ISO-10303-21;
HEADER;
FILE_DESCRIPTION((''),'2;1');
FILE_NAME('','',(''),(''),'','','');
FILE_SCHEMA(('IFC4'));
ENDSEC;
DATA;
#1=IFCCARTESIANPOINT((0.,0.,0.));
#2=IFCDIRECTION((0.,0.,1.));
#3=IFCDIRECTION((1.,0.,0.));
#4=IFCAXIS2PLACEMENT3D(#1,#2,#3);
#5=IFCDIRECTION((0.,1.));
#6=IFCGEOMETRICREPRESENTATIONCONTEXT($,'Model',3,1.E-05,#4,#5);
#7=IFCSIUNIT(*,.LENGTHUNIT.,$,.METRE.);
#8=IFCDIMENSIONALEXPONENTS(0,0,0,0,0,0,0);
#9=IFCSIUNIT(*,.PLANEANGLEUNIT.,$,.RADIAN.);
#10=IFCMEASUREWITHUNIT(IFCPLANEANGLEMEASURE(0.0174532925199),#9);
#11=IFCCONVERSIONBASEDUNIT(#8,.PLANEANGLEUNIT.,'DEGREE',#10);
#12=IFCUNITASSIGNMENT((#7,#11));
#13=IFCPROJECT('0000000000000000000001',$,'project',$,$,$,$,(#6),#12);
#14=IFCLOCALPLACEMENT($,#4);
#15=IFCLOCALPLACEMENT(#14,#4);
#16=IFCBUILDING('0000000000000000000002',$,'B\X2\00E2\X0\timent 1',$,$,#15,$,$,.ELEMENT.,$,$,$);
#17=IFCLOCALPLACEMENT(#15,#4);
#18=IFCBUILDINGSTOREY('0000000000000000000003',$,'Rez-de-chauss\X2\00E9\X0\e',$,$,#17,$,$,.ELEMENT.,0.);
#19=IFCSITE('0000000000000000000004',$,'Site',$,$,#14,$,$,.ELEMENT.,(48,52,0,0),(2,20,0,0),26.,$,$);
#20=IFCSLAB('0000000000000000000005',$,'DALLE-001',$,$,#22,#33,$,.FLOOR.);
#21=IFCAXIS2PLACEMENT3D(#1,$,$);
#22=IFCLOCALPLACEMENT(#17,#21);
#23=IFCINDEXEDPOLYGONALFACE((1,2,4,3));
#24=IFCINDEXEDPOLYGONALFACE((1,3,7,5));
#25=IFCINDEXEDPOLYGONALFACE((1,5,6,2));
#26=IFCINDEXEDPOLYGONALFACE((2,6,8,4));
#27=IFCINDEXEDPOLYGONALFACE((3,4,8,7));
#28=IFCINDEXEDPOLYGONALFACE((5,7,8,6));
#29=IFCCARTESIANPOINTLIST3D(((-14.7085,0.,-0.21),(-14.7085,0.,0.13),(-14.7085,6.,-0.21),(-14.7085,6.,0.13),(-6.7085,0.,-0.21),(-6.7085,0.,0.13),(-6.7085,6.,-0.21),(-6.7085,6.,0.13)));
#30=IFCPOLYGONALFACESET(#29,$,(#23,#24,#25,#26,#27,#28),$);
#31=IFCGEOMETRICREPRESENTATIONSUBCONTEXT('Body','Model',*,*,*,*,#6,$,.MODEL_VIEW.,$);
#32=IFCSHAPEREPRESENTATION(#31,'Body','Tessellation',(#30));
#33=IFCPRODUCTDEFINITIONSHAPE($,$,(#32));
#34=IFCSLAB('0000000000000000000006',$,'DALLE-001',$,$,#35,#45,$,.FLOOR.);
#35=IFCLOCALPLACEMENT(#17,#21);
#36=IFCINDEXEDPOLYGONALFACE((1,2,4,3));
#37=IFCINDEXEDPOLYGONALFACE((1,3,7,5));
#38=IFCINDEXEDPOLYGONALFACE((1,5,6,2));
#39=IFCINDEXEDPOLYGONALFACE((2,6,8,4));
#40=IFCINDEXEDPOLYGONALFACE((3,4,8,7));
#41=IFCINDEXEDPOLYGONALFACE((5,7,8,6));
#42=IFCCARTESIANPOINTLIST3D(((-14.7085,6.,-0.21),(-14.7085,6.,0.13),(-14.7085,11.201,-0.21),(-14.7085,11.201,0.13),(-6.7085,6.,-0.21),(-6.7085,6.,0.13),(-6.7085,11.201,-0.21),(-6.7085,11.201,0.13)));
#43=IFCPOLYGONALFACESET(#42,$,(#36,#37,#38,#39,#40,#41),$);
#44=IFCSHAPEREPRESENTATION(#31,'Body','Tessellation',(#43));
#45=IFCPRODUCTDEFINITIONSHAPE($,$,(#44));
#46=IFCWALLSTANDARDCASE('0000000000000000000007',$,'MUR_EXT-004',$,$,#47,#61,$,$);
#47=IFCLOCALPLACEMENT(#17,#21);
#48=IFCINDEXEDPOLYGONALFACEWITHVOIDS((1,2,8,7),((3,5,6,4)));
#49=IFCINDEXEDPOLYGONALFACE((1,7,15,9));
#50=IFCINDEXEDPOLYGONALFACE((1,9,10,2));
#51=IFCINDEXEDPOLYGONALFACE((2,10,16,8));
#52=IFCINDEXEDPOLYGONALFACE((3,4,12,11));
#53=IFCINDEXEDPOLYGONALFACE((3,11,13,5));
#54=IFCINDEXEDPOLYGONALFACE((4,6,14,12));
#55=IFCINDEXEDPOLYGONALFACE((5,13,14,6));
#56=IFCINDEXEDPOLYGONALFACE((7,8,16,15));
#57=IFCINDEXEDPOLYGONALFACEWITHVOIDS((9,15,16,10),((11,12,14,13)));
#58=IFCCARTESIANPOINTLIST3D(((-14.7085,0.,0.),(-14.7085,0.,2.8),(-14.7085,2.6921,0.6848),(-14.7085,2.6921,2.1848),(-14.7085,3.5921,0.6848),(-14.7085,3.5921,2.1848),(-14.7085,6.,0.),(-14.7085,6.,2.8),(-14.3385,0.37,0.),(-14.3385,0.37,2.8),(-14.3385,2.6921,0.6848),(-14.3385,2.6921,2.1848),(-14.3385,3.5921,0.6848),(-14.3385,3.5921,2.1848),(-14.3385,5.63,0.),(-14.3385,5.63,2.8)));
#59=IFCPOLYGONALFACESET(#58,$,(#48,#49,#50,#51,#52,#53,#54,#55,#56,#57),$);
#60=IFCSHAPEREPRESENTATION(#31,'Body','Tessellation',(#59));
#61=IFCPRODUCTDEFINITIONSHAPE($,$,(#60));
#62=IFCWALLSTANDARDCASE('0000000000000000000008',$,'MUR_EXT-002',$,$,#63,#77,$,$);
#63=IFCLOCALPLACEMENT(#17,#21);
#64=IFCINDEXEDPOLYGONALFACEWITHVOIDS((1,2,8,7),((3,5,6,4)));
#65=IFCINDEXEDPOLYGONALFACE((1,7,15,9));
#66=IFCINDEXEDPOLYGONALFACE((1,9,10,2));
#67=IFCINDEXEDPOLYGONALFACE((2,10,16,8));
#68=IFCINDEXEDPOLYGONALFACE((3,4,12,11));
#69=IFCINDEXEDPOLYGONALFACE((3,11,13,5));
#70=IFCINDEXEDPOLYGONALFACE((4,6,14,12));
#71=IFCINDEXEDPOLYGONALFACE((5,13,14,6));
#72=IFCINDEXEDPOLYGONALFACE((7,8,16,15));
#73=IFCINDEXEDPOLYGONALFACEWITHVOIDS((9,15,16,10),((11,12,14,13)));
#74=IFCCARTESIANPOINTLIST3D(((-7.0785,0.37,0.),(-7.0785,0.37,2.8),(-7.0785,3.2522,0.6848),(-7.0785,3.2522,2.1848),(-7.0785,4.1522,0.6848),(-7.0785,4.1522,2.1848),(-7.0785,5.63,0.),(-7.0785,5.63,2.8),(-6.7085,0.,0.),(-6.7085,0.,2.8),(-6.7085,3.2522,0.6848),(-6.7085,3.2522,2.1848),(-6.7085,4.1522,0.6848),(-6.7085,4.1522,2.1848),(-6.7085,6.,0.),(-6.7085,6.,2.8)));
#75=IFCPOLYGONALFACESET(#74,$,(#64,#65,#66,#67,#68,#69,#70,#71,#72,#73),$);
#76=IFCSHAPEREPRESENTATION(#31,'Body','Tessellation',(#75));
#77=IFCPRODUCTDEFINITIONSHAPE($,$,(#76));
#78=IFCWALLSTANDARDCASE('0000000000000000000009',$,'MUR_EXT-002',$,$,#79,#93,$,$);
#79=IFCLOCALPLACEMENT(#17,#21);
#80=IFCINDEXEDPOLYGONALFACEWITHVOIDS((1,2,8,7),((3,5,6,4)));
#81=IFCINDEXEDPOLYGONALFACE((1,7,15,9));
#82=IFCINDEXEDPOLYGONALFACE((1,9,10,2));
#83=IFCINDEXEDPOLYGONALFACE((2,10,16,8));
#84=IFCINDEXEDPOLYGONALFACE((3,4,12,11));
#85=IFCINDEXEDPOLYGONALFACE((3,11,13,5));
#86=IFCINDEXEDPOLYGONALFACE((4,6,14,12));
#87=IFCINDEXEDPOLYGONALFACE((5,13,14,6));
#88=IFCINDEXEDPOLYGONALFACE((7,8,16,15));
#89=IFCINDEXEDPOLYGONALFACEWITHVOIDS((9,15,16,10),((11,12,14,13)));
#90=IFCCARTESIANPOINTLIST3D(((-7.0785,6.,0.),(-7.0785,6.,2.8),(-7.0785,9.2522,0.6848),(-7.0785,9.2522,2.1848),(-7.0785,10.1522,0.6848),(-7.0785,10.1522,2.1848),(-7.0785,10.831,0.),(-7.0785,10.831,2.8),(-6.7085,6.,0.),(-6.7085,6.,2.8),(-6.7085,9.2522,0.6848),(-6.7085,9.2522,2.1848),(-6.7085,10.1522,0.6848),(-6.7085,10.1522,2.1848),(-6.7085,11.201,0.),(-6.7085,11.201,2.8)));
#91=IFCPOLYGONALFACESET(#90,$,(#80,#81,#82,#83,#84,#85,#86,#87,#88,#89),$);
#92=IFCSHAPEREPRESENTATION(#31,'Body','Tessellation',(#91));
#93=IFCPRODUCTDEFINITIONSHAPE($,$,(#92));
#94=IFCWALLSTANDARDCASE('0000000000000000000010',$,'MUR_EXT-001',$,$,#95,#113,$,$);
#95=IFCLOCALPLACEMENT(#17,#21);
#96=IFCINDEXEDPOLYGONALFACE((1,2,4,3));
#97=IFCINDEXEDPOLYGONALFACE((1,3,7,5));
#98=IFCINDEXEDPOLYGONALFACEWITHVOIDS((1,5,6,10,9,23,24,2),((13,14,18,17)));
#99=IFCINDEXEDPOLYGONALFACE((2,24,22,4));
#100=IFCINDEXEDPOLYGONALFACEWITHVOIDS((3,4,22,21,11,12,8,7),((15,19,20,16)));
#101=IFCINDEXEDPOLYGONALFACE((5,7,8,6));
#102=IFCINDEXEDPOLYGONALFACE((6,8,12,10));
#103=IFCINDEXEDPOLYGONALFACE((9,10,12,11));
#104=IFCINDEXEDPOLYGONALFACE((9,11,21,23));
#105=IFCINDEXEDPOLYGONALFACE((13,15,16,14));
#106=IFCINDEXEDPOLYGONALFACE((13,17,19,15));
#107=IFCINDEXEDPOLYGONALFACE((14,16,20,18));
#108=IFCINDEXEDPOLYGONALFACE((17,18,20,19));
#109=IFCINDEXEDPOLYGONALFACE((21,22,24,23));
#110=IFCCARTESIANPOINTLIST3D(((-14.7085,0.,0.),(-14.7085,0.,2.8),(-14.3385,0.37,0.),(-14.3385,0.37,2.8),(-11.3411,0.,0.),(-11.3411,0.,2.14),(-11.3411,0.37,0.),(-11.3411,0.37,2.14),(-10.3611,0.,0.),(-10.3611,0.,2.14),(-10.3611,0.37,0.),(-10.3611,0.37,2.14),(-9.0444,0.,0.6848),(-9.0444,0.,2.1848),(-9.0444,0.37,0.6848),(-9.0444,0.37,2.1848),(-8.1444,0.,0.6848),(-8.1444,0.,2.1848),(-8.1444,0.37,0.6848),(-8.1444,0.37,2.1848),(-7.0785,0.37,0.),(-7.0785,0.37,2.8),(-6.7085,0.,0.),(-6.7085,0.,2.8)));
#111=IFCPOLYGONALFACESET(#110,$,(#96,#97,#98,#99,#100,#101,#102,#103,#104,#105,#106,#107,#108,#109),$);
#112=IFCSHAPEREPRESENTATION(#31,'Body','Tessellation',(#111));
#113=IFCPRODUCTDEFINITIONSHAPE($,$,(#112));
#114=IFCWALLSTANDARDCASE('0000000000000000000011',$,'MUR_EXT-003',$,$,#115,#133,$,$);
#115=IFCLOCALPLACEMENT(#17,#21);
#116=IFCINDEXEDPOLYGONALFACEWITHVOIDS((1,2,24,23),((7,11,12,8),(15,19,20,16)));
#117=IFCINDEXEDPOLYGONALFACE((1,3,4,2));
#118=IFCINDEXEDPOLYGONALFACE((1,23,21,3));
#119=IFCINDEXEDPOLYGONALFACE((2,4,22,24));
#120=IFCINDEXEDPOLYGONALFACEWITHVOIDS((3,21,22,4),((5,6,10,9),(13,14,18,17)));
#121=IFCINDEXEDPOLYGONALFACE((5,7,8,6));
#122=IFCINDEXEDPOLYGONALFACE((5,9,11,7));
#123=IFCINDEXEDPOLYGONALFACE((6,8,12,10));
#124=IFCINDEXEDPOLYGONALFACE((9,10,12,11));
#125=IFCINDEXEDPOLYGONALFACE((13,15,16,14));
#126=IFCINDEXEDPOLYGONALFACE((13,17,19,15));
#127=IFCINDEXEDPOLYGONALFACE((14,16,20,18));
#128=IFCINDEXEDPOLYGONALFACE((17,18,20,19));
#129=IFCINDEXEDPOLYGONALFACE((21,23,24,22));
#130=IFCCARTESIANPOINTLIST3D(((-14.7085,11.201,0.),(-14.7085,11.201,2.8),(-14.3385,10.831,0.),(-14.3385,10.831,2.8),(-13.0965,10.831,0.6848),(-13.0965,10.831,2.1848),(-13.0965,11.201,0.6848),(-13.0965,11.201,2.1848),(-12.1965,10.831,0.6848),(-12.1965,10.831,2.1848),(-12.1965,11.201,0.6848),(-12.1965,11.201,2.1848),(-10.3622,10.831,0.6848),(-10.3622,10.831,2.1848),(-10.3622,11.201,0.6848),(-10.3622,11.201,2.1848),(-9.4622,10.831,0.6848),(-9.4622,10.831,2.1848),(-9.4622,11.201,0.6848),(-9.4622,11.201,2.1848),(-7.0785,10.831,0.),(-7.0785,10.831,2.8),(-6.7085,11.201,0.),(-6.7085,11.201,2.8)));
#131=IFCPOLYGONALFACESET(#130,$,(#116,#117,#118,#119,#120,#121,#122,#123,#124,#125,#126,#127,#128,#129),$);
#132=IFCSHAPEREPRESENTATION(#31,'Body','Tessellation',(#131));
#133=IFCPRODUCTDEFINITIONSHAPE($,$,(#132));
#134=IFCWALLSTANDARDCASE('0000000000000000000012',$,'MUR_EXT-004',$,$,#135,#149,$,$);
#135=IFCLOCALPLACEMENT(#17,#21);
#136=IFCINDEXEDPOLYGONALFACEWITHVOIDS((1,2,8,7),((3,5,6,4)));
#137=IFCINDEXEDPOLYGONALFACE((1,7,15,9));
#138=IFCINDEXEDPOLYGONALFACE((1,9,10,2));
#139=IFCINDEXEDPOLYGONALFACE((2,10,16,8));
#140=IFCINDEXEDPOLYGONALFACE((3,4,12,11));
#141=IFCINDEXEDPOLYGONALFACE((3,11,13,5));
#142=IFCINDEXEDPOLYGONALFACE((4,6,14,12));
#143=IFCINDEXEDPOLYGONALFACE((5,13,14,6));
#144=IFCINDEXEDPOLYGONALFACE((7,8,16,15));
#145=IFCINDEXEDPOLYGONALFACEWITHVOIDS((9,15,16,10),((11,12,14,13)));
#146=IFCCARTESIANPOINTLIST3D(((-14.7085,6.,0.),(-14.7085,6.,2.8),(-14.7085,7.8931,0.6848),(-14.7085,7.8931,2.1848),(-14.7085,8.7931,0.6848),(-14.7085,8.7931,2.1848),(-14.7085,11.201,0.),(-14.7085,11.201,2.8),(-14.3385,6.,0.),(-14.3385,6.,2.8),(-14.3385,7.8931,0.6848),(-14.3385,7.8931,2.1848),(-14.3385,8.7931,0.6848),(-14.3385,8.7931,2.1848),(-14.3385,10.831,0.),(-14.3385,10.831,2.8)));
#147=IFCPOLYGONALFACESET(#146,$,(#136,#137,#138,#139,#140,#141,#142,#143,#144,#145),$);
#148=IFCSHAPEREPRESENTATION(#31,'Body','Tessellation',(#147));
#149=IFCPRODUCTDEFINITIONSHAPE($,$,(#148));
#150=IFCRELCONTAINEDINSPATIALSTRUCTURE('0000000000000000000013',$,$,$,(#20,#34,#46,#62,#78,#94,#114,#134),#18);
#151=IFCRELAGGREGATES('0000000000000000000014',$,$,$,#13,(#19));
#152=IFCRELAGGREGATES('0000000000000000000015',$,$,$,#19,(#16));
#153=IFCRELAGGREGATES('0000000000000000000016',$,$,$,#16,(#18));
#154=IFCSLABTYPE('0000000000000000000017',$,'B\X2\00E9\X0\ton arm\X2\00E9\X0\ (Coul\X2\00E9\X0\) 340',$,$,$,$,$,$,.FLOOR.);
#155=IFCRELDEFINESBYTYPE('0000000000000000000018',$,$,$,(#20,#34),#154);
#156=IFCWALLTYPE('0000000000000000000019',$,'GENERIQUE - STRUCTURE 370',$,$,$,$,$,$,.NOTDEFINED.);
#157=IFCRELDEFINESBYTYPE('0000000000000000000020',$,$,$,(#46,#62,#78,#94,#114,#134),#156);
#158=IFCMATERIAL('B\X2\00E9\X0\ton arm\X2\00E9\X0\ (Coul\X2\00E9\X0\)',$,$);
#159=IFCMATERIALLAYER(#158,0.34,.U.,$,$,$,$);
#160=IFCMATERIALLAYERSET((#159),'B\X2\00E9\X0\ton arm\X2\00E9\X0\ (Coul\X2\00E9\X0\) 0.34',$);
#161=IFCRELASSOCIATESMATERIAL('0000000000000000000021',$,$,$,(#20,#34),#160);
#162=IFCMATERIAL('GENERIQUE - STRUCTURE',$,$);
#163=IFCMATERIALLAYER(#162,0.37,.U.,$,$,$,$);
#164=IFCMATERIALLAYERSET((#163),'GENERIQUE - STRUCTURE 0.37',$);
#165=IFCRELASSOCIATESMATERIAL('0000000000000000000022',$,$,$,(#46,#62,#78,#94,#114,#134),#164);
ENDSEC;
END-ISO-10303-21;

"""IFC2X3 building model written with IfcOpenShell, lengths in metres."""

from ifc_helpers import new_model, entity, si_unit, converted_unit, direction, frame, origin_with_axes, origin_2d_with_axis, place, context, subcontext, project, spatial, polyline, rectangle, outline, extrude, material, layer, layer_set, layer_usage, type_object, element, save


model = new_model("IFC2X3")

# Units and contexts
model_context = context("Model", 3, precision=1e-05, world=origin_with_axes(), true_north=direction((0.0, 1.0)))
body_context = subcontext(model_context, "Body", "Model", "MODEL_VIEW")
ifc_project = project(units=[si_unit("LENGTHUNIT", "METRE"), converted_unit("PLANEANGLEUNIT", "DEGREE", entity("IfcPlaneAngleMeasure", 0.0174532925199), si_unit("PLANEANGLEUNIT", "RADIAN"), dimensions=[0, 0, 0, 0, 0, 0, 0])], contexts=[model_context])

# Site, building, storey
site_placement = place(None, origin_with_axes())
site = spatial("IfcSite", under=ifc_project, at=site_placement, Name="Site", CompositionType="ELEMENT", RefLatitude=(48, 52, 0, 0), RefLongitude=(2, 20, 0, 0), RefElevation=26.0)
building_placement = place(site_placement, origin_with_axes())
building = spatial("IfcBuilding", under=site, at=building_placement, Name="Bâtiment 1", CompositionType="ELEMENT")
storey_placement = place(building_placement, origin_with_axes())
storey = spatial("IfcBuildingStorey", under=building, at=storey_placement, Name="Rez-de-chaussée", CompositionType="ELEMENT", Elevation=0.0)

# Slabs
ifc_material_1 = material(Name="Béton armé (Coulé)")
ifc_layer_1 = layer(ifc_material_1, 0.34, ventilated="UNKNOWN")
ifc_layer_set_1 = layer_set([ifc_layer_1], Name="Béton armé (Coulé) 0.34")
ifc_layer_usage_1 = layer_usage(ifc_layer_set_1, "AXIS3", "NEGATIVE", 0.34)
slab_type = type_object("IfcSlabType", Name="Béton armé (Coulé) 340", PredefinedType="FLOOR")
slab_1_placement = place(storey_placement, frame((-14.7085, 0.0, 0.13), z_axis=(0.0, 0.0, 1.0), x_axis=(1.0, 0.0, 0.0)))
element("IfcSlab", 1, at=slab_1_placement, inside=storey, type_object=slab_type, material=ifc_layer_usage_1, Name="DALLE-001", PredefinedType="FLOOR", context=body_context, shape_type="SweptSolid", body=[
    extrude(outline(polyline([(0.0, 0.0), (8.0, 0.0), (8.0, 6.0), (0.0, 6.0), (0.0, 0.0)])), frame((0.0, 0.0, -0.34), z_axis=(0.0, 0.0, 1.0), x_axis=(1.0, 0.0, 0.0)), (0.0, 0.0, 1.0), 0.34),
])
ifc_layer_usage_2 = layer_usage(ifc_layer_set_1, "AXIS3", "NEGATIVE", 0.34)
slab_2_placement = place(storey_placement, frame((-14.7085, 6.0, 0.13), z_axis=(0.0, 0.0, 1.0), x_axis=(1.0, 0.0, 0.0)))
element("IfcSlab", 2, at=slab_2_placement, inside=storey, type_object=slab_type, material=ifc_layer_usage_2, Name="DALLE-001", PredefinedType="FLOOR", context=body_context, shape_type="SweptSolid", body=[
    extrude(outline(polyline([(0.0, 0.0), (8.0, 0.0), (8.0, 5.201), (0.0, 5.201), (0.0, 0.0)])), frame((0.0, 0.0, -0.34), z_axis=(0.0, 0.0, 1.0), x_axis=(1.0, 0.0, 0.0)), (0.0, 0.0, 1.0), 0.34),
])

# Walls, openings
ifc_material_2 = material(Name="GENERIQUE - STRUCTURE")
ifc_layer_2 = layer(ifc_material_2, 0.37, ventilated="UNKNOWN")
ifc_layer_set_2 = layer_set([ifc_layer_2], Name="GENERIQUE - STRUCTURE 0.37")
ifc_layer_usage_3 = layer_usage(ifc_layer_set_2, "AXIS2", "POSITIVE", 0.0)
wall_type_1 = type_object("IfcWallType", Name="GENERIQUE - STRUCTURE 370", PredefinedType="NOTDEFINED")
wall_1_placement = place(storey_placement, frame((-14.7085, 6.0, 0.0), z_axis=(0.0, 0.0, 1.0), x_axis=(0.0, -1.0, 0.0)))
wall_1 = element("IfcWallStandardCase", 3, at=wall_1_placement, inside=storey, type_object=wall_type_1, material=ifc_layer_usage_3, Name="MUR_EXT-004", context=body_context, shape_type="SweptSolid", body=[
    extrude(outline(polyline([(0.0, 0.0), (6.0, 0.0), (5.63, 0.37), (0.37, 0.37), (0.0, 0.0)])), origin_with_axes(), (0.0, 0.0, 1.0), 2.8),
])
opening_1_placement = place(wall_1_placement, frame((2.8579, 0.0, 0.6848), z_axis=(0.0, 0.0, 1.0), x_axis=(1.0, 0.0, 0.0)))
element("IfcOpeningElement", 4, at=opening_1_placement, cuts=wall_1, context=body_context, shape_type="SweptSolid", body=[
    extrude(rectangle(XDim=0.9, YDim=1.5, at=origin_2d_with_axis()), frame((0.0, 0.37, 0.75), z_axis=(0.0, -1.0, 0.0), x_axis=(-1.0, 0.0, 0.0)), (0.0, 0.0, 1.0), 1.11),
])
ifc_layer_usage_4 = layer_usage(ifc_layer_set_2, "AXIS2", "POSITIVE", 0.0)
wall_2_placement = place(storey_placement, frame((-6.7085, 0.0, 0.0), z_axis=(0.0, 0.0, 1.0), x_axis=(0.0, 1.0, 0.0)))
wall_2 = element("IfcWallStandardCase", 5, at=wall_2_placement, inside=storey, type_object=wall_type_1, material=ifc_layer_usage_4, Name="MUR_EXT-002", context=body_context, shape_type="SweptSolid", body=[
    extrude(outline(polyline([(0.0, 0.0), (6.0, 0.0), (5.63, 0.37), (0.37, 0.37), (0.0, 0.0)])), origin_with_axes(), (0.0, 0.0, 1.0), 2.8),
])
opening_2_placement = place(wall_2_placement, frame((3.7022, 0.0, 0.6848), z_axis=(0.0, 0.0, 1.0), x_axis=(1.0, 0.0, 0.0)))
element("IfcOpeningElement", 6, at=opening_2_placement, cuts=wall_2, context=body_context, shape_type="SweptSolid", body=[
    extrude(rectangle(XDim=0.9, YDim=1.5, at=origin_2d_with_axis()), frame((0.0, 0.37, 0.75), z_axis=(0.0, -1.0, 0.0), x_axis=(-1.0, 0.0, 0.0)), (0.0, 0.0, 1.0), 1.11),
])
ifc_layer_usage_5 = layer_usage(ifc_layer_set_2, "AXIS2", "POSITIVE", 0.0)
wall_3_placement = place(storey_placement, frame((-6.7085, 6.0, 0.0), z_axis=(0.0, 0.0, 1.0), x_axis=(0.0, 1.0, 0.0)))
wall_3 = element("IfcWallStandardCase", 7, at=wall_3_placement, inside=storey, type_object=wall_type_1, material=ifc_layer_usage_5, Name="MUR_EXT-002", context=body_context, shape_type="SweptSolid", body=[
    extrude(outline(polyline([(0.0, 0.0), (5.201, 0.0), (4.831, 0.37), (0.0, 0.37), (0.0, 0.0)])), origin_with_axes(), (0.0, 0.0, 1.0), 2.8),
])
opening_3_placement = place(wall_3_placement, frame((3.7022, 0.0, 0.6848), z_axis=(0.0, 0.0, 1.0), x_axis=(1.0, 0.0, 0.0)))
element("IfcOpeningElement", 8, at=opening_3_placement, cuts=wall_3, context=body_context, shape_type="SweptSolid", body=[
    extrude(rectangle(XDim=0.9, YDim=1.5, at=origin_2d_with_axis()), frame((0.0, 0.37, 0.75), z_axis=(0.0, -1.0, 0.0), x_axis=(-1.0, 0.0, 0.0)), (0.0, 0.0, 1.0), 1.11),
])

# Walls, openings
ifc_layer_usage_6 = layer_usage(ifc_layer_set_2, "AXIS2", "POSITIVE", 0.0)
wall_4_placement = place(storey_placement, frame((-14.7085, 0.0, 0.0), z_axis=(0.0, 0.0, 1.0), x_axis=(1.0, 0.0, 0.0)))
wall_4 = element("IfcWallStandardCase", 9, at=wall_4_placement, inside=storey, type_object=wall_type_1, material=ifc_layer_usage_6, Name="MUR_EXT-001", context=body_context, shape_type="SweptSolid", body=[
    extrude(outline(polyline([(0.0, 0.0), (8.0, 0.0), (7.63, 0.37), (0.37, 0.37), (0.0, 0.0)])), origin_with_axes(), (0.0, 0.0, 1.0), 2.8),
])
opening_4_placement = place(wall_4_placement, frame((6.1141, 0.0, 0.6848), z_axis=(0.0, 0.0, 1.0), x_axis=(1.0, 0.0, 0.0)))
element("IfcOpeningElement", 10, at=opening_4_placement, cuts=wall_4, context=body_context, shape_type="SweptSolid", body=[
    extrude(rectangle(XDim=0.9, YDim=1.5, at=origin_2d_with_axis()), frame((0.0, 0.37, 0.75), z_axis=(0.0, 1.0, 0.0), x_axis=(1.0, 0.0, 0.0)), (0.0, 0.0, -1.0), 1.11),
])
opening_5_placement = place(wall_4_placement, frame((3.8574, 0.0, 0.0), z_axis=(0.0, 0.0, 1.0), x_axis=(1.0, 0.0, 0.0)))
element("IfcOpeningElement", 11, at=opening_5_placement, cuts=wall_4, context=body_context, shape_type="SweptSolid", body=[
    extrude(rectangle(XDim=0.98, YDim=2.14, at=origin_2d_with_axis()), frame((0.0, 0.37, 1.07), z_axis=(0.0, 1.0, 0.0), x_axis=(1.0, 0.0, 0.0)), (0.0, 0.0, -1.0), 1.11),
])
ifc_layer_usage_7 = layer_usage(ifc_layer_set_2, "AXIS2", "POSITIVE", 0.0)
wall_5_placement = place(storey_placement, frame((-6.7085, 11.201, 0.0), z_axis=(0.0, 0.0, 1.0), x_axis=(-1.0, 0.0, 0.0)))
wall_5 = element("IfcWallStandardCase", 12, at=wall_5_placement, inside=storey, type_object=wall_type_1, material=ifc_layer_usage_7, Name="MUR_EXT-003", context=body_context, shape_type="SweptSolid", body=[
    extrude(outline(polyline([(0.0, 0.0), (8.0, 0.0), (7.63, 0.37), (0.37, 0.37), (0.0, 0.0)])), origin_with_axes(), (0.0, 0.0, 1.0), 2.8),
])
opening_6_placement = place(wall_5_placement, frame((3.2036, 0.0, 0.6848), z_axis=(0.0, 0.0, 1.0), x_axis=(1.0, 0.0, 0.0)))
element("IfcOpeningElement", 13, at=opening_6_placement, cuts=wall_5, context=body_context, shape_type="SweptSolid", body=[
    extrude(rectangle(XDim=0.9, YDim=1.5, at=origin_2d_with_axis()), frame((0.0, 0.37, 0.75), z_axis=(0.0, -1.0, 0.0), x_axis=(-1.0, 0.0, 0.0)), (0.0, 0.0, 1.0), 1.11),
])
opening_7_placement = place(wall_5_placement, frame((5.938, 0.0, 0.6848), z_axis=(0.0, 0.0, 1.0), x_axis=(1.0, 0.0, 0.0)))
element("IfcOpeningElement", 14, at=opening_7_placement, cuts=wall_5, context=body_context, shape_type="SweptSolid", body=[
    extrude(rectangle(XDim=0.9, YDim=1.5, at=origin_2d_with_axis()), frame((0.0, 0.37, 0.75), z_axis=(0.0, 1.0, 0.0), x_axis=(1.0, 0.0, 0.0)), (0.0, 0.0, -1.0), 1.11),
])

# Wall, opening
ifc_layer_usage_8 = layer_usage(ifc_layer_set_2, "AXIS2", "POSITIVE", 0.0)
wall_6_placement = place(storey_placement, frame((-14.7085, 11.201, 0.0), z_axis=(0.0, 0.0, 1.0), x_axis=(0.0, -1.0, 0.0)))
wall_6 = element("IfcWallStandardCase", 15, at=wall_6_placement, inside=storey, type_object=wall_type_1, material=ifc_layer_usage_8, Name="MUR_EXT-004", context=body_context, shape_type="SweptSolid", body=[
    extrude(outline(polyline([(0.0, 0.0), (5.201, 0.0), (5.201, 0.37), (0.37, 0.37), (0.0, 0.0)])), origin_with_axes(), (0.0, 0.0, 1.0), 2.8),
])
opening_8_placement = place(wall_6_placement, frame((2.8579, 0.0, 0.6848), z_axis=(0.0, 0.0, 1.0), x_axis=(1.0, 0.0, 0.0)))
element("IfcOpeningElement", 16, at=opening_8_placement, cuts=wall_6, context=body_context, shape_type="SweptSolid", body=[
    extrude(rectangle(XDim=0.9, YDim=1.5, at=origin_2d_with_axis()), frame((0.0, 0.37, 0.75), z_axis=(0.0, -1.0, 0.0), x_axis=(-1.0, 0.0, 0.0)), (0.0, 0.0, 1.0), 1.11),
])

save(model, "model.ifc")
